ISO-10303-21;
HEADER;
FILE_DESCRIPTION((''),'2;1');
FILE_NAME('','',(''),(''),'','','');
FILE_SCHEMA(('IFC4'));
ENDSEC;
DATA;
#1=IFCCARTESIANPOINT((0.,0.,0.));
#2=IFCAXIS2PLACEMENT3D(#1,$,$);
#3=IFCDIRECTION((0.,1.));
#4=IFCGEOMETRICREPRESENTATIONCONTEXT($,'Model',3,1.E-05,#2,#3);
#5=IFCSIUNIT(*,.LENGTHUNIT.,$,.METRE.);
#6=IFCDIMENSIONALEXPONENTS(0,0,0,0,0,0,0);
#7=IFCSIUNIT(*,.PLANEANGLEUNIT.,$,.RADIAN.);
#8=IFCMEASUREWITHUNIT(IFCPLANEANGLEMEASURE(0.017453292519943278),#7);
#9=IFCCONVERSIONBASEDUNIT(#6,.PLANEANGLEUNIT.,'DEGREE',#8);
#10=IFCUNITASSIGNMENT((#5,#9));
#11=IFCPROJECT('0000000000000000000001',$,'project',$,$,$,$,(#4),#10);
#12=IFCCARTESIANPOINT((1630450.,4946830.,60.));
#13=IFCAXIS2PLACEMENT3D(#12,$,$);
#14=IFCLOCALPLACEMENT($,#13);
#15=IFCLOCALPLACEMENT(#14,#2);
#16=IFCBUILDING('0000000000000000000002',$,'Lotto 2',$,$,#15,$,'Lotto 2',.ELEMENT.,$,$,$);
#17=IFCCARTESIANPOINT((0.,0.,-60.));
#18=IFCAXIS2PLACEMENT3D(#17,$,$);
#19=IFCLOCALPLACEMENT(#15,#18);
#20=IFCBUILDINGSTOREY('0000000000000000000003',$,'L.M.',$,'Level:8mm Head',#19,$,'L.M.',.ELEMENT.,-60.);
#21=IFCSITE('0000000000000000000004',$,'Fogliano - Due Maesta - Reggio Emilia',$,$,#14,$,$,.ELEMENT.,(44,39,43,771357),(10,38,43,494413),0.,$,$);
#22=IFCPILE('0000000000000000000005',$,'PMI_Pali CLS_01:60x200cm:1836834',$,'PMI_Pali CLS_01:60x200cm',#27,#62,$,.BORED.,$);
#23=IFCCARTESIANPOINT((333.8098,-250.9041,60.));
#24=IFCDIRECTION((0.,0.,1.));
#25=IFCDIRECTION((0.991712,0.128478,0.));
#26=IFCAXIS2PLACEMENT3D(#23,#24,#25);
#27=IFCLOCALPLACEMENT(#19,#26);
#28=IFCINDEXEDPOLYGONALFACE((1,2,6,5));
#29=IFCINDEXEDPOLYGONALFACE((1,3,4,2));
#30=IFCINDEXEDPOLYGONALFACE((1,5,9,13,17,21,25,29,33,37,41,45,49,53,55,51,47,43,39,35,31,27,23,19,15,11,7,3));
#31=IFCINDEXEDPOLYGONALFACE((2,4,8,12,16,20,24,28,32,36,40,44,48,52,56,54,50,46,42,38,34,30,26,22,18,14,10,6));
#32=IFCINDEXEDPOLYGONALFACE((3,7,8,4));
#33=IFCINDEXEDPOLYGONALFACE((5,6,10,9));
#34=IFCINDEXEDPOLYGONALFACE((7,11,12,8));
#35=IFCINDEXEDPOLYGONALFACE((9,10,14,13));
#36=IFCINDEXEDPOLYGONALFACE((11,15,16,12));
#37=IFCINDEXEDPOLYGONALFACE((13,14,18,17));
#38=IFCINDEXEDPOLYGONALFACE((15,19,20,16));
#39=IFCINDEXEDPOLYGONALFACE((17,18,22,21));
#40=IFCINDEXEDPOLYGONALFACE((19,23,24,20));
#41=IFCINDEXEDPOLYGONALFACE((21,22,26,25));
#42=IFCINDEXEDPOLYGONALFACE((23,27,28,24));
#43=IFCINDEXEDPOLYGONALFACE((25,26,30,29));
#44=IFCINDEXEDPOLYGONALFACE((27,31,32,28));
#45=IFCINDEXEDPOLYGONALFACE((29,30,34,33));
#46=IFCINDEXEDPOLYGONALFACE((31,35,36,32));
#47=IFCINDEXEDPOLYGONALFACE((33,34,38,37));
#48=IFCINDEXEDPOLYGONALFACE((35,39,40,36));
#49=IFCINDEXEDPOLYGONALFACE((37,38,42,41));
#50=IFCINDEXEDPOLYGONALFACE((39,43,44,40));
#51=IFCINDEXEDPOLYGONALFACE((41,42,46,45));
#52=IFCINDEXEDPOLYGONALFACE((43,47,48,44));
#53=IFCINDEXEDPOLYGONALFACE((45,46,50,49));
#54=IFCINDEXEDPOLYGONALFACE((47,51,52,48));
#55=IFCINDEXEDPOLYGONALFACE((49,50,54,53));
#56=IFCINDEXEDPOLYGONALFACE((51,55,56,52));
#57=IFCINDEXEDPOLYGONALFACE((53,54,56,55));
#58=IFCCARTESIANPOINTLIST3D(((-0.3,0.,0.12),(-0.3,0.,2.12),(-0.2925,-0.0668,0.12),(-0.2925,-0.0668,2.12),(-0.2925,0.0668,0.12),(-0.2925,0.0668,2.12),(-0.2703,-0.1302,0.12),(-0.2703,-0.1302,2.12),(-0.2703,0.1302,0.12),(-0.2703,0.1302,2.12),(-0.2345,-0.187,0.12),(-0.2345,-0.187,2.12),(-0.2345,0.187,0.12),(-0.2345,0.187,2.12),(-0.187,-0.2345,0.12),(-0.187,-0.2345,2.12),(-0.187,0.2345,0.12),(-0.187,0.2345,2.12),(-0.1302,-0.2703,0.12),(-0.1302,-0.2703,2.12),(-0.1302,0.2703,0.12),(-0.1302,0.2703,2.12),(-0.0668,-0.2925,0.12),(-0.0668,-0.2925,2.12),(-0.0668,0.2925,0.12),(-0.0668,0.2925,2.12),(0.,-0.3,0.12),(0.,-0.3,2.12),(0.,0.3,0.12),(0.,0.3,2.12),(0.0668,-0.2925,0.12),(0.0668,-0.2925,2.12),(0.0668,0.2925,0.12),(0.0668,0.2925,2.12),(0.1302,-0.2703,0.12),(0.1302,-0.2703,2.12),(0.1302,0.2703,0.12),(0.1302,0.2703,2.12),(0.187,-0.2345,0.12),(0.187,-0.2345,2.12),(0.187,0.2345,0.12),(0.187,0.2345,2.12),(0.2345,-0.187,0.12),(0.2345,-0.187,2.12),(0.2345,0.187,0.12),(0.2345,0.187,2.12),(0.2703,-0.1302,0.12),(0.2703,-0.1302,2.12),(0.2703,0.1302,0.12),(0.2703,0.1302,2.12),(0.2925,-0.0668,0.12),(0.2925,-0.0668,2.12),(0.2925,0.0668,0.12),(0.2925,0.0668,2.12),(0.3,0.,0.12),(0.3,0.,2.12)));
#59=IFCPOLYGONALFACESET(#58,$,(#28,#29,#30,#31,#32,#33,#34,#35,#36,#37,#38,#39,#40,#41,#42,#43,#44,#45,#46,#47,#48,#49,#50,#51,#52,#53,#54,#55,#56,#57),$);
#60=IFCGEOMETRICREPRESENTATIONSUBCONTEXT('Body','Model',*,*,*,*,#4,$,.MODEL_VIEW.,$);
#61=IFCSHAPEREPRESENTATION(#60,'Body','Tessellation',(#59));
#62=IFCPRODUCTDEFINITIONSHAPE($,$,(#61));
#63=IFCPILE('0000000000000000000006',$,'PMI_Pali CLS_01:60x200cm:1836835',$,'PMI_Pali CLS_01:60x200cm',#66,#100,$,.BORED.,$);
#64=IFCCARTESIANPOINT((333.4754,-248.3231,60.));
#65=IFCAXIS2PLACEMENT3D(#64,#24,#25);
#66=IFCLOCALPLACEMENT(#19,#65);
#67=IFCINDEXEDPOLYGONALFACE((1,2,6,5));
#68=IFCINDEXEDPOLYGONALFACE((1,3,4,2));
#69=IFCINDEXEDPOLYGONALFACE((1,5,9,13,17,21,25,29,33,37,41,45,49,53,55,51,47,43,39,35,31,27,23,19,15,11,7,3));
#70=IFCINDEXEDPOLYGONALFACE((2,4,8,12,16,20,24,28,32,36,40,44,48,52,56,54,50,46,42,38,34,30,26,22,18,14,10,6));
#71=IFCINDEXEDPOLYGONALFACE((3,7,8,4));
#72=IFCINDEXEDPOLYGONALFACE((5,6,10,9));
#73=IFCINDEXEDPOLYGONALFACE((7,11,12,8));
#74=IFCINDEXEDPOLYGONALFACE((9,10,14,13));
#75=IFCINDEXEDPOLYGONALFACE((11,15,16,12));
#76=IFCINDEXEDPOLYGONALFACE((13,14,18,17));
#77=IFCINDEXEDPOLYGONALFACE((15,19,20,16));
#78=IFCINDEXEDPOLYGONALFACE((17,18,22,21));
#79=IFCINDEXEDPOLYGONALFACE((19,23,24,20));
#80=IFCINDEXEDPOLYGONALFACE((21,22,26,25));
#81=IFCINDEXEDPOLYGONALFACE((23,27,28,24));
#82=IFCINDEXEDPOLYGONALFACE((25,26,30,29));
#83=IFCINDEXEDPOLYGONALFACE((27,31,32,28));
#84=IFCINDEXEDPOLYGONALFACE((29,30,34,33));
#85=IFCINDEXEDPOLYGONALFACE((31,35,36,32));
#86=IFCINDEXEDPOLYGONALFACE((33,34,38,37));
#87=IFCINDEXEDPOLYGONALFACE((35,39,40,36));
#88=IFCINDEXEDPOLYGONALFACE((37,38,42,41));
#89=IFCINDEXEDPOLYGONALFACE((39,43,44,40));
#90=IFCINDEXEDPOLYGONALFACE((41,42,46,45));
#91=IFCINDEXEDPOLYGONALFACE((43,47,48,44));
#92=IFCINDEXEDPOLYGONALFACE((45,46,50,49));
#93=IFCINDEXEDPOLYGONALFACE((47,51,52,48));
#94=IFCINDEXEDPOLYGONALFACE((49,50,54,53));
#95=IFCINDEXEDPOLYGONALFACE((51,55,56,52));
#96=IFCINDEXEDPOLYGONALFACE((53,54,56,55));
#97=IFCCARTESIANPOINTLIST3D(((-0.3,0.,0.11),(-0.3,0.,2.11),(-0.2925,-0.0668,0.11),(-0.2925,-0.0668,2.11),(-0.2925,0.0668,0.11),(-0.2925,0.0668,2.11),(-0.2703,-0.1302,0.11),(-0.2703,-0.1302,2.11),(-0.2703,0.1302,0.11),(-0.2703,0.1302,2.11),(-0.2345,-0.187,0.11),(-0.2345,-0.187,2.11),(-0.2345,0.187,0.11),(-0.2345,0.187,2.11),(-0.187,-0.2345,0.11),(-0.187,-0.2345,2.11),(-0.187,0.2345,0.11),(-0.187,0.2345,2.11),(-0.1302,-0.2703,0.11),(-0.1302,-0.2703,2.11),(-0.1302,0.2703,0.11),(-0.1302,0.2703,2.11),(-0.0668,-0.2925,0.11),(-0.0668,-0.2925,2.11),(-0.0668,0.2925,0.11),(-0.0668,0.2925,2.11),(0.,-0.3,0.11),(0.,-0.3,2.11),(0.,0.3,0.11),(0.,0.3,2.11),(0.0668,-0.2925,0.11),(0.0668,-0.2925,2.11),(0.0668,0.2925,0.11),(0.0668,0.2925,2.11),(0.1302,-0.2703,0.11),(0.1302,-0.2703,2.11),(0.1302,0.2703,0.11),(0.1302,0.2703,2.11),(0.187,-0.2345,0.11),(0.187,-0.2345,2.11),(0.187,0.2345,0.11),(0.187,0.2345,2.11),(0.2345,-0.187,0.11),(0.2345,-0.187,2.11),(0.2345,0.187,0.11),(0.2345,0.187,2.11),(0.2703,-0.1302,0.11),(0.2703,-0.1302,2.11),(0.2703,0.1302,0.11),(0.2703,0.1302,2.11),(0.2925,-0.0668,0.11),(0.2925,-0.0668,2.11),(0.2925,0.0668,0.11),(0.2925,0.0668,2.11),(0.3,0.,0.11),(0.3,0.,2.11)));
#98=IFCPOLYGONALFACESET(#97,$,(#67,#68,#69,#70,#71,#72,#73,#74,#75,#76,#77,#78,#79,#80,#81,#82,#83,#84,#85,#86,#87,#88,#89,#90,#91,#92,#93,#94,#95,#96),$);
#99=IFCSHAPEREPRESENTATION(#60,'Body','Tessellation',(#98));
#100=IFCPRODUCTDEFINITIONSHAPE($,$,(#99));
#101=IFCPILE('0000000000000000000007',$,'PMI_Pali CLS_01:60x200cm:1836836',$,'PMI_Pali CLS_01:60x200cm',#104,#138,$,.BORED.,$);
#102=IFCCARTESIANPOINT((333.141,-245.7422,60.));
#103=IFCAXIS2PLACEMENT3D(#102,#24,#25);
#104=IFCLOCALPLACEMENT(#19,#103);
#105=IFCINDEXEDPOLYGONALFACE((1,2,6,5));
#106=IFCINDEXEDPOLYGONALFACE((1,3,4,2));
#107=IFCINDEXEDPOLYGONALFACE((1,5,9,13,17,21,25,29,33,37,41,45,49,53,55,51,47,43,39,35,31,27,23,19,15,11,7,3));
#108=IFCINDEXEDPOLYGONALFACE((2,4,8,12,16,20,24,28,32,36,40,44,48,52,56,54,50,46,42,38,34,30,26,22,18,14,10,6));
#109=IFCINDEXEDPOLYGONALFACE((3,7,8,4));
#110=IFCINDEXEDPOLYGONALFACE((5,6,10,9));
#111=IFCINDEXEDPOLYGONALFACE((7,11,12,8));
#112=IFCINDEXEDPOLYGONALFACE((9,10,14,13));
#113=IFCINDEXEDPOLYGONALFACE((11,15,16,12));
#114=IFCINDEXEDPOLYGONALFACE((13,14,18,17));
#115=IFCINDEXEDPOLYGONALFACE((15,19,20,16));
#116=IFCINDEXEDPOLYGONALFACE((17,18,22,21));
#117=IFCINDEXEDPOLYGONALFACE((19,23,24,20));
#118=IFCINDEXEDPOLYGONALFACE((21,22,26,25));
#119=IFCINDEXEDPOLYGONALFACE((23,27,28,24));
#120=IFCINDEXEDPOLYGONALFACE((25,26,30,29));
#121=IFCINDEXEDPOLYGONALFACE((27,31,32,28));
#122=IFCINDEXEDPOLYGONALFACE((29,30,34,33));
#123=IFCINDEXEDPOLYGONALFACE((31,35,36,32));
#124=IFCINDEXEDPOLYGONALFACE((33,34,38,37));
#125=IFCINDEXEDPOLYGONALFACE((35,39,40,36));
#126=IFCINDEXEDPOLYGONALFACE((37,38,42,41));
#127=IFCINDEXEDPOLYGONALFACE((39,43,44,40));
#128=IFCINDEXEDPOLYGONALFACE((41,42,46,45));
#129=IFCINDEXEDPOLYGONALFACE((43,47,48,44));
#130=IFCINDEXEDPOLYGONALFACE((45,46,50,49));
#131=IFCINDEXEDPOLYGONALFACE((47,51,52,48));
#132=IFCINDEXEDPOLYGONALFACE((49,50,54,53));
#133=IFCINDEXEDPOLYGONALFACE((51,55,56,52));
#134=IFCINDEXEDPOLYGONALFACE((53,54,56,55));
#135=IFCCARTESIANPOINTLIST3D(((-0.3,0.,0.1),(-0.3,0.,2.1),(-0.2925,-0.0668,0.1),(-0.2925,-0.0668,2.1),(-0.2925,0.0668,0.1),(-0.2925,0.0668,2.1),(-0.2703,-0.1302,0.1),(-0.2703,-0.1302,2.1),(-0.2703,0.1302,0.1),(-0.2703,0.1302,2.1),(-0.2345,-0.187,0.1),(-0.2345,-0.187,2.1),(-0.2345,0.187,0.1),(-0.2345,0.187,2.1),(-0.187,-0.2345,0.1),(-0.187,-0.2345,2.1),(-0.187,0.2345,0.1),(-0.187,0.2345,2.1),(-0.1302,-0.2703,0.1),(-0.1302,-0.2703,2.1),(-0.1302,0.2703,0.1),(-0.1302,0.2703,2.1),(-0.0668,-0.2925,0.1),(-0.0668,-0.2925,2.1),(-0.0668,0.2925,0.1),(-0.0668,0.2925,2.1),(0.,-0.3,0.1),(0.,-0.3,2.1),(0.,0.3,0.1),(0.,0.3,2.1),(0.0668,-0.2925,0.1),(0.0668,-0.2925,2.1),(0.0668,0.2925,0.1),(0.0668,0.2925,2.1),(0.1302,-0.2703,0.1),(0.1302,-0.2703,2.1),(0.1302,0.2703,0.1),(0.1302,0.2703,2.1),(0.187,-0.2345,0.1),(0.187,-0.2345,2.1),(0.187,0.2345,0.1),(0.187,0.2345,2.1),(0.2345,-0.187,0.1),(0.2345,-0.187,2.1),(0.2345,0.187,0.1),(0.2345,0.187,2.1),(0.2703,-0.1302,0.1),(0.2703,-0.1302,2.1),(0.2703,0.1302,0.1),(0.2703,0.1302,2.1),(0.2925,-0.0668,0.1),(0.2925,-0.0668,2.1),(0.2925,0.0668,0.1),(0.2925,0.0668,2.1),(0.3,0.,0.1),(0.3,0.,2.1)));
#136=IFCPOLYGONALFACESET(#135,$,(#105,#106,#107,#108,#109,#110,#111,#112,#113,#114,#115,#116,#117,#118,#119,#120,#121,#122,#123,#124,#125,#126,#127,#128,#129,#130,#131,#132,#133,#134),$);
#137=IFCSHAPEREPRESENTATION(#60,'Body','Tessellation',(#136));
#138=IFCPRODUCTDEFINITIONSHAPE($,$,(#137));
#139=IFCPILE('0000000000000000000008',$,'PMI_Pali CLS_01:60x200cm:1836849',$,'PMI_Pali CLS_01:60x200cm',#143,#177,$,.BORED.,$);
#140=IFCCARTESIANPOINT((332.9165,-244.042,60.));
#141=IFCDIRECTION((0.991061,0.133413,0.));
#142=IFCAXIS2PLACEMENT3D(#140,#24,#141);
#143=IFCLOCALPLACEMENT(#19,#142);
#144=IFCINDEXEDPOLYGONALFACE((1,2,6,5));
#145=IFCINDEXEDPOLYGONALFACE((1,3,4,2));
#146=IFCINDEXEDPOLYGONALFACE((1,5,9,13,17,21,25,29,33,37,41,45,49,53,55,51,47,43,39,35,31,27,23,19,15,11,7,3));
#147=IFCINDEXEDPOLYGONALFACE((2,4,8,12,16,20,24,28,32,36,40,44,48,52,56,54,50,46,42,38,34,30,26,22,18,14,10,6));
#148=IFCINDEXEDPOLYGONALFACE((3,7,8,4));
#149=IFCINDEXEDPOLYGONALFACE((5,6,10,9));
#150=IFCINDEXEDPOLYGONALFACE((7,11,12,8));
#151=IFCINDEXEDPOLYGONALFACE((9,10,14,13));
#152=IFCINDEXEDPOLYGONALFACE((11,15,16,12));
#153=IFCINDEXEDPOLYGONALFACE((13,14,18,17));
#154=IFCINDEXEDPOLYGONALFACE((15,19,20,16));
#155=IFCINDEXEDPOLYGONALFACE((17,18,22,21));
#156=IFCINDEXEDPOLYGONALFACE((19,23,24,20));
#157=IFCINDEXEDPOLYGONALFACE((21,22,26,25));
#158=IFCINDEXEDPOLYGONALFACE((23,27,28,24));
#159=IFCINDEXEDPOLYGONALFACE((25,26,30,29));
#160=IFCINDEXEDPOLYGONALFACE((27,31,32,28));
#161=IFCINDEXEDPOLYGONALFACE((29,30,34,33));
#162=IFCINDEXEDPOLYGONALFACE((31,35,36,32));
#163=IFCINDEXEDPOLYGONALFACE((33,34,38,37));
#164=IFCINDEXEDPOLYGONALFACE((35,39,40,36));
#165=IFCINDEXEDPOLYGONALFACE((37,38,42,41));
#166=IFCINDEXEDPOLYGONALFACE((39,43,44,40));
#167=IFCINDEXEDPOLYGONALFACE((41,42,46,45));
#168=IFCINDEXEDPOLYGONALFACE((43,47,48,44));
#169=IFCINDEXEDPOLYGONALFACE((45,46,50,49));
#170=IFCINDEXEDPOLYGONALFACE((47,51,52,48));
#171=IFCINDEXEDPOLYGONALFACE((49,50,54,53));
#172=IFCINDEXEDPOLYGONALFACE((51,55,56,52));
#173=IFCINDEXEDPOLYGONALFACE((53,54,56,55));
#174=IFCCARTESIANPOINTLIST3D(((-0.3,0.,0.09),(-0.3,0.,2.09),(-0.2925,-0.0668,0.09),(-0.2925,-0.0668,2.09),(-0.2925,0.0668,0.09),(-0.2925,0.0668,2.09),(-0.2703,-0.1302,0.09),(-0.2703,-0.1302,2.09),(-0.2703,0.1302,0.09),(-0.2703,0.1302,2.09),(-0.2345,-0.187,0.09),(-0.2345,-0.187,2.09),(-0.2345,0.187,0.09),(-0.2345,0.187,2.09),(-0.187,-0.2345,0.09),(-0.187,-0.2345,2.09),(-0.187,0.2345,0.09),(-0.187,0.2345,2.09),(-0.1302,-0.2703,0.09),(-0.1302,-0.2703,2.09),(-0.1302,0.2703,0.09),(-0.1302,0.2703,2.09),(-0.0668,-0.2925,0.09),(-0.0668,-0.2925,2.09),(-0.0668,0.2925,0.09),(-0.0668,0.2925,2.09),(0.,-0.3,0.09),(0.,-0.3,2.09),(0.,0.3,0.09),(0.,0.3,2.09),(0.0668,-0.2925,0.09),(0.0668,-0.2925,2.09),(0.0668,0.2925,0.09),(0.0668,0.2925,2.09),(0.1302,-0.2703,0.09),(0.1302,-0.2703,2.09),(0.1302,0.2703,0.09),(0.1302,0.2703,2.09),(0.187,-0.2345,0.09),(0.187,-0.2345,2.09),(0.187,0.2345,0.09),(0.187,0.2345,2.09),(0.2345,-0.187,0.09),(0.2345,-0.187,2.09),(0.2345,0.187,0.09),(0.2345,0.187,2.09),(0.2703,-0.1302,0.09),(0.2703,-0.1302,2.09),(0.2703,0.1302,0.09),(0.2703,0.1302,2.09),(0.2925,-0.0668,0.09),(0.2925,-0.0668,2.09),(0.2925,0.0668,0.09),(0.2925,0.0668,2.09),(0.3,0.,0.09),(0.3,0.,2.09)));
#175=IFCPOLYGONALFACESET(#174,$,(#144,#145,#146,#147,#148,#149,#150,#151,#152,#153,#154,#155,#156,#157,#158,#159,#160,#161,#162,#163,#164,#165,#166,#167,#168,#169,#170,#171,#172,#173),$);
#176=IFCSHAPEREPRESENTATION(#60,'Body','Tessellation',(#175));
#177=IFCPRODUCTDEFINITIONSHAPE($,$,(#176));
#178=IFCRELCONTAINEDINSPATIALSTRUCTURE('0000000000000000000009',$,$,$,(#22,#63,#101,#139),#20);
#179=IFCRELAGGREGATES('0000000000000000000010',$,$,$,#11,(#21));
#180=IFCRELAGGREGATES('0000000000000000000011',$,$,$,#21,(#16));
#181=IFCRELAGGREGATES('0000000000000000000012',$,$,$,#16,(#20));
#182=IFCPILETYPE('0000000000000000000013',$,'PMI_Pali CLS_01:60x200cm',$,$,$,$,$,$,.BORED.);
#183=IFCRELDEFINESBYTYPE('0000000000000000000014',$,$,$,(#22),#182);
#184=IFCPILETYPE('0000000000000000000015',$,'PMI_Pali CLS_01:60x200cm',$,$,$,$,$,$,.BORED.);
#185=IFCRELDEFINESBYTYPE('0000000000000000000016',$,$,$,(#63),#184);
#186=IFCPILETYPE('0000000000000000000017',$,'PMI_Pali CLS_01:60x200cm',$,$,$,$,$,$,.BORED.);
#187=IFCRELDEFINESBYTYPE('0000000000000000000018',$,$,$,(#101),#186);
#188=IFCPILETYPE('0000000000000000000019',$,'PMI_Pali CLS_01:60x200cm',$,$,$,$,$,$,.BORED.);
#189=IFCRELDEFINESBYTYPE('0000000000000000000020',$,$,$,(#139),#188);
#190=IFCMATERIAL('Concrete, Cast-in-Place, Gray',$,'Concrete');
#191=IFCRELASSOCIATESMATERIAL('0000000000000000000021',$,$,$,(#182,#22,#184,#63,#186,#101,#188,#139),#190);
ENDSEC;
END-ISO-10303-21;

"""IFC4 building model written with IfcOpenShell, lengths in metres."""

from ifc_helpers import new_model, entity, si_unit, converted_unit, direction, frame, origin, place, context, subcontext, project, spatial, arc, indexed_curve, outline, extrude, source, transform, mapped, material, type_object, type_shapes, element, save


model = new_model("IFC4")

# Units and contexts
model_context = context("Model", 3, precision=1e-05, world=origin(), true_north=direction((0.0, 1.0)))
body_context = subcontext(model_context, "Body", "Model", "MODEL_VIEW")
ifc_project = project(units=[si_unit("LENGTHUNIT", "METRE"), converted_unit("PLANEANGLEUNIT", "DEGREE", entity("IfcPlaneAngleMeasure", 0.017453292519943278), si_unit("PLANEANGLEUNIT", "RADIAN"), dimensions=[0, 0, 0, 0, 0, 0, 0])], contexts=[model_context])

# Site, building, storey
site_placement = place(None, frame((1630450.0, 4946830.0, 60.0)))
site = spatial("IfcSite", under=ifc_project, at=site_placement, Name="Fogliano - Due Maesta - Reggio Emilia", CompositionType="ELEMENT", RefLatitude=(44, 39, 43, 771357), RefLongitude=(10, 38, 43, 494413), RefElevation=0.0)
building_placement = place(site_placement, origin())
building = spatial("IfcBuilding", under=site, at=building_placement, Name="Lotto 2", LongName="Lotto 2", CompositionType="ELEMENT")
storey_placement = place(building_placement, frame((0.0, 0.0, -60.0)))
storey = spatial("IfcBuildingStorey", under=building, at=storey_placement, Name="L.M.", ObjectType="Level:8mm Head", LongName="L.M.", CompositionType="ELEMENT", Elevation=-60.0)

# Piles
ifc_material_1 = material(Name="Concrete, Cast-in-Place, Gray", Category="Concrete")
pile_type_1 = type_object("IfcPileType", Name="PMI_Pali CLS_01:60x200cm", PredefinedType="BORED", material=ifc_material_1)
shared_shape_1 = source(origin(), body_context, "Body", "SweptSolid", [
    extrude(outline(indexed_curve([(-0.3, 0.0), (0.0, -0.3), (0.3, 0.0), (0.0, 0.3)], segments=[arc(1, 2, 3), arc(3, 4, 1)], self_intersect=False)), frame((0.0, 0.0, 0.12)), (0.0, 0.0, 1.0), 2.0),
])
type_shapes(pile_type_1, [shared_shape_1])
pile_1_placement = place(storey_placement, frame((333.8098, -250.9041, 60.0), z_axis=(0.0, 0.0, 1.0), x_axis=(0.991712, 0.128478, 0.0)))
element("IfcPile", 1, at=pile_1_placement, inside=storey, type_object=pile_type_1, material=ifc_material_1, Name="PMI_Pali CLS_01:60x200cm:1836834", ObjectType="PMI_Pali CLS_01:60x200cm", PredefinedType="BORED", context=body_context, shape_type="MappedRepresentation", body=[
    mapped(shared_shape_1, transform((0.0, 0.0, 0.0), scale=1.0)),
])
pile_type_2 = type_object("IfcPileType", Name="PMI_Pali CLS_01:60x200cm", PredefinedType="BORED", material=ifc_material_1)
shared_shape_2 = source(origin(), body_context, "Body", "SweptSolid", [
    extrude(outline(indexed_curve([(-0.3, 0.0), (0.0, -0.3), (0.3, 0.0), (0.0, 0.3)], segments=[arc(1, 2, 3), arc(3, 4, 1)], self_intersect=False)), frame((0.0, 0.0, 0.11)), (0.0, 0.0, 1.0), 2.0),
])
type_shapes(pile_type_2, [shared_shape_2])
pile_2_placement = place(storey_placement, frame((333.4754, -248.3231, 60.0), z_axis=(0.0, 0.0, 1.0), x_axis=(0.991712, 0.128478, 0.0)))
element("IfcPile", 2, at=pile_2_placement, inside=storey, type_object=pile_type_2, material=ifc_material_1, Name="PMI_Pali CLS_01:60x200cm:1836835", ObjectType="PMI_Pali CLS_01:60x200cm", PredefinedType="BORED", context=body_context, shape_type="MappedRepresentation", body=[
    mapped(shared_shape_2, transform((0.0, 0.0, 0.0), scale=1.0)),
])
pile_type_3 = type_object("IfcPileType", Name="PMI_Pali CLS_01:60x200cm", PredefinedType="BORED", material=ifc_material_1)
shared_shape_3 = source(origin(), body_context, "Body", "SweptSolid", [
    extrude(outline(indexed_curve([(-0.3, 0.0), (0.0, -0.3), (0.3, 0.0), (0.0, 0.3)], segments=[arc(1, 2, 3), arc(3, 4, 1)], self_intersect=False)), frame((0.0, 0.0, 0.1)), (0.0, 0.0, 1.0), 2.0),
])
type_shapes(pile_type_3, [shared_shape_3])
pile_3_placement = place(storey_placement, frame((333.141, -245.7422, 60.0), z_axis=(0.0, 0.0, 1.0), x_axis=(0.991712, 0.128478, 0.0)))
element("IfcPile", 3, at=pile_3_placement, inside=storey, type_object=pile_type_3, material=ifc_material_1, Name="PMI_Pali CLS_01:60x200cm:1836836", ObjectType="PMI_Pali CLS_01:60x200cm", PredefinedType="BORED", context=body_context, shape_type="MappedRepresentation", body=[
    mapped(shared_shape_3, transform((0.0, 0.0, 0.0), scale=1.0)),
])
pile_type_4 = type_object("IfcPileType", Name="PMI_Pali CLS_01:60x200cm", PredefinedType="BORED", material=ifc_material_1)
shared_shape_4 = source(origin(), body_context, "Body", "SweptSolid", [
    extrude(outline(indexed_curve([(-0.3, 0.0), (0.0, -0.3), (0.3, 0.0), (0.0, 0.3)], segments=[arc(1, 2, 3), arc(3, 4, 1)], self_intersect=False)), frame((0.0, 0.0, 0.09)), (0.0, 0.0, 1.0), 2.0),
])
type_shapes(pile_type_4, [shared_shape_4])
pile_4_placement = place(storey_placement, frame((332.9165, -244.042, 60.0), z_axis=(0.0, 0.0, 1.0), x_axis=(0.991061, 0.133413, 0.0)))
element("IfcPile", 4, at=pile_4_placement, inside=storey, type_object=pile_type_4, material=ifc_material_1, Name="PMI_Pali CLS_01:60x200cm:1836849", ObjectType="PMI_Pali CLS_01:60x200cm", PredefinedType="BORED", context=body_context, shape_type="MappedRepresentation", body=[
    mapped(shared_shape_4, transform((0.0, 0.0, 0.0), scale=1.0)),
])

save(model, "model.ifc")
